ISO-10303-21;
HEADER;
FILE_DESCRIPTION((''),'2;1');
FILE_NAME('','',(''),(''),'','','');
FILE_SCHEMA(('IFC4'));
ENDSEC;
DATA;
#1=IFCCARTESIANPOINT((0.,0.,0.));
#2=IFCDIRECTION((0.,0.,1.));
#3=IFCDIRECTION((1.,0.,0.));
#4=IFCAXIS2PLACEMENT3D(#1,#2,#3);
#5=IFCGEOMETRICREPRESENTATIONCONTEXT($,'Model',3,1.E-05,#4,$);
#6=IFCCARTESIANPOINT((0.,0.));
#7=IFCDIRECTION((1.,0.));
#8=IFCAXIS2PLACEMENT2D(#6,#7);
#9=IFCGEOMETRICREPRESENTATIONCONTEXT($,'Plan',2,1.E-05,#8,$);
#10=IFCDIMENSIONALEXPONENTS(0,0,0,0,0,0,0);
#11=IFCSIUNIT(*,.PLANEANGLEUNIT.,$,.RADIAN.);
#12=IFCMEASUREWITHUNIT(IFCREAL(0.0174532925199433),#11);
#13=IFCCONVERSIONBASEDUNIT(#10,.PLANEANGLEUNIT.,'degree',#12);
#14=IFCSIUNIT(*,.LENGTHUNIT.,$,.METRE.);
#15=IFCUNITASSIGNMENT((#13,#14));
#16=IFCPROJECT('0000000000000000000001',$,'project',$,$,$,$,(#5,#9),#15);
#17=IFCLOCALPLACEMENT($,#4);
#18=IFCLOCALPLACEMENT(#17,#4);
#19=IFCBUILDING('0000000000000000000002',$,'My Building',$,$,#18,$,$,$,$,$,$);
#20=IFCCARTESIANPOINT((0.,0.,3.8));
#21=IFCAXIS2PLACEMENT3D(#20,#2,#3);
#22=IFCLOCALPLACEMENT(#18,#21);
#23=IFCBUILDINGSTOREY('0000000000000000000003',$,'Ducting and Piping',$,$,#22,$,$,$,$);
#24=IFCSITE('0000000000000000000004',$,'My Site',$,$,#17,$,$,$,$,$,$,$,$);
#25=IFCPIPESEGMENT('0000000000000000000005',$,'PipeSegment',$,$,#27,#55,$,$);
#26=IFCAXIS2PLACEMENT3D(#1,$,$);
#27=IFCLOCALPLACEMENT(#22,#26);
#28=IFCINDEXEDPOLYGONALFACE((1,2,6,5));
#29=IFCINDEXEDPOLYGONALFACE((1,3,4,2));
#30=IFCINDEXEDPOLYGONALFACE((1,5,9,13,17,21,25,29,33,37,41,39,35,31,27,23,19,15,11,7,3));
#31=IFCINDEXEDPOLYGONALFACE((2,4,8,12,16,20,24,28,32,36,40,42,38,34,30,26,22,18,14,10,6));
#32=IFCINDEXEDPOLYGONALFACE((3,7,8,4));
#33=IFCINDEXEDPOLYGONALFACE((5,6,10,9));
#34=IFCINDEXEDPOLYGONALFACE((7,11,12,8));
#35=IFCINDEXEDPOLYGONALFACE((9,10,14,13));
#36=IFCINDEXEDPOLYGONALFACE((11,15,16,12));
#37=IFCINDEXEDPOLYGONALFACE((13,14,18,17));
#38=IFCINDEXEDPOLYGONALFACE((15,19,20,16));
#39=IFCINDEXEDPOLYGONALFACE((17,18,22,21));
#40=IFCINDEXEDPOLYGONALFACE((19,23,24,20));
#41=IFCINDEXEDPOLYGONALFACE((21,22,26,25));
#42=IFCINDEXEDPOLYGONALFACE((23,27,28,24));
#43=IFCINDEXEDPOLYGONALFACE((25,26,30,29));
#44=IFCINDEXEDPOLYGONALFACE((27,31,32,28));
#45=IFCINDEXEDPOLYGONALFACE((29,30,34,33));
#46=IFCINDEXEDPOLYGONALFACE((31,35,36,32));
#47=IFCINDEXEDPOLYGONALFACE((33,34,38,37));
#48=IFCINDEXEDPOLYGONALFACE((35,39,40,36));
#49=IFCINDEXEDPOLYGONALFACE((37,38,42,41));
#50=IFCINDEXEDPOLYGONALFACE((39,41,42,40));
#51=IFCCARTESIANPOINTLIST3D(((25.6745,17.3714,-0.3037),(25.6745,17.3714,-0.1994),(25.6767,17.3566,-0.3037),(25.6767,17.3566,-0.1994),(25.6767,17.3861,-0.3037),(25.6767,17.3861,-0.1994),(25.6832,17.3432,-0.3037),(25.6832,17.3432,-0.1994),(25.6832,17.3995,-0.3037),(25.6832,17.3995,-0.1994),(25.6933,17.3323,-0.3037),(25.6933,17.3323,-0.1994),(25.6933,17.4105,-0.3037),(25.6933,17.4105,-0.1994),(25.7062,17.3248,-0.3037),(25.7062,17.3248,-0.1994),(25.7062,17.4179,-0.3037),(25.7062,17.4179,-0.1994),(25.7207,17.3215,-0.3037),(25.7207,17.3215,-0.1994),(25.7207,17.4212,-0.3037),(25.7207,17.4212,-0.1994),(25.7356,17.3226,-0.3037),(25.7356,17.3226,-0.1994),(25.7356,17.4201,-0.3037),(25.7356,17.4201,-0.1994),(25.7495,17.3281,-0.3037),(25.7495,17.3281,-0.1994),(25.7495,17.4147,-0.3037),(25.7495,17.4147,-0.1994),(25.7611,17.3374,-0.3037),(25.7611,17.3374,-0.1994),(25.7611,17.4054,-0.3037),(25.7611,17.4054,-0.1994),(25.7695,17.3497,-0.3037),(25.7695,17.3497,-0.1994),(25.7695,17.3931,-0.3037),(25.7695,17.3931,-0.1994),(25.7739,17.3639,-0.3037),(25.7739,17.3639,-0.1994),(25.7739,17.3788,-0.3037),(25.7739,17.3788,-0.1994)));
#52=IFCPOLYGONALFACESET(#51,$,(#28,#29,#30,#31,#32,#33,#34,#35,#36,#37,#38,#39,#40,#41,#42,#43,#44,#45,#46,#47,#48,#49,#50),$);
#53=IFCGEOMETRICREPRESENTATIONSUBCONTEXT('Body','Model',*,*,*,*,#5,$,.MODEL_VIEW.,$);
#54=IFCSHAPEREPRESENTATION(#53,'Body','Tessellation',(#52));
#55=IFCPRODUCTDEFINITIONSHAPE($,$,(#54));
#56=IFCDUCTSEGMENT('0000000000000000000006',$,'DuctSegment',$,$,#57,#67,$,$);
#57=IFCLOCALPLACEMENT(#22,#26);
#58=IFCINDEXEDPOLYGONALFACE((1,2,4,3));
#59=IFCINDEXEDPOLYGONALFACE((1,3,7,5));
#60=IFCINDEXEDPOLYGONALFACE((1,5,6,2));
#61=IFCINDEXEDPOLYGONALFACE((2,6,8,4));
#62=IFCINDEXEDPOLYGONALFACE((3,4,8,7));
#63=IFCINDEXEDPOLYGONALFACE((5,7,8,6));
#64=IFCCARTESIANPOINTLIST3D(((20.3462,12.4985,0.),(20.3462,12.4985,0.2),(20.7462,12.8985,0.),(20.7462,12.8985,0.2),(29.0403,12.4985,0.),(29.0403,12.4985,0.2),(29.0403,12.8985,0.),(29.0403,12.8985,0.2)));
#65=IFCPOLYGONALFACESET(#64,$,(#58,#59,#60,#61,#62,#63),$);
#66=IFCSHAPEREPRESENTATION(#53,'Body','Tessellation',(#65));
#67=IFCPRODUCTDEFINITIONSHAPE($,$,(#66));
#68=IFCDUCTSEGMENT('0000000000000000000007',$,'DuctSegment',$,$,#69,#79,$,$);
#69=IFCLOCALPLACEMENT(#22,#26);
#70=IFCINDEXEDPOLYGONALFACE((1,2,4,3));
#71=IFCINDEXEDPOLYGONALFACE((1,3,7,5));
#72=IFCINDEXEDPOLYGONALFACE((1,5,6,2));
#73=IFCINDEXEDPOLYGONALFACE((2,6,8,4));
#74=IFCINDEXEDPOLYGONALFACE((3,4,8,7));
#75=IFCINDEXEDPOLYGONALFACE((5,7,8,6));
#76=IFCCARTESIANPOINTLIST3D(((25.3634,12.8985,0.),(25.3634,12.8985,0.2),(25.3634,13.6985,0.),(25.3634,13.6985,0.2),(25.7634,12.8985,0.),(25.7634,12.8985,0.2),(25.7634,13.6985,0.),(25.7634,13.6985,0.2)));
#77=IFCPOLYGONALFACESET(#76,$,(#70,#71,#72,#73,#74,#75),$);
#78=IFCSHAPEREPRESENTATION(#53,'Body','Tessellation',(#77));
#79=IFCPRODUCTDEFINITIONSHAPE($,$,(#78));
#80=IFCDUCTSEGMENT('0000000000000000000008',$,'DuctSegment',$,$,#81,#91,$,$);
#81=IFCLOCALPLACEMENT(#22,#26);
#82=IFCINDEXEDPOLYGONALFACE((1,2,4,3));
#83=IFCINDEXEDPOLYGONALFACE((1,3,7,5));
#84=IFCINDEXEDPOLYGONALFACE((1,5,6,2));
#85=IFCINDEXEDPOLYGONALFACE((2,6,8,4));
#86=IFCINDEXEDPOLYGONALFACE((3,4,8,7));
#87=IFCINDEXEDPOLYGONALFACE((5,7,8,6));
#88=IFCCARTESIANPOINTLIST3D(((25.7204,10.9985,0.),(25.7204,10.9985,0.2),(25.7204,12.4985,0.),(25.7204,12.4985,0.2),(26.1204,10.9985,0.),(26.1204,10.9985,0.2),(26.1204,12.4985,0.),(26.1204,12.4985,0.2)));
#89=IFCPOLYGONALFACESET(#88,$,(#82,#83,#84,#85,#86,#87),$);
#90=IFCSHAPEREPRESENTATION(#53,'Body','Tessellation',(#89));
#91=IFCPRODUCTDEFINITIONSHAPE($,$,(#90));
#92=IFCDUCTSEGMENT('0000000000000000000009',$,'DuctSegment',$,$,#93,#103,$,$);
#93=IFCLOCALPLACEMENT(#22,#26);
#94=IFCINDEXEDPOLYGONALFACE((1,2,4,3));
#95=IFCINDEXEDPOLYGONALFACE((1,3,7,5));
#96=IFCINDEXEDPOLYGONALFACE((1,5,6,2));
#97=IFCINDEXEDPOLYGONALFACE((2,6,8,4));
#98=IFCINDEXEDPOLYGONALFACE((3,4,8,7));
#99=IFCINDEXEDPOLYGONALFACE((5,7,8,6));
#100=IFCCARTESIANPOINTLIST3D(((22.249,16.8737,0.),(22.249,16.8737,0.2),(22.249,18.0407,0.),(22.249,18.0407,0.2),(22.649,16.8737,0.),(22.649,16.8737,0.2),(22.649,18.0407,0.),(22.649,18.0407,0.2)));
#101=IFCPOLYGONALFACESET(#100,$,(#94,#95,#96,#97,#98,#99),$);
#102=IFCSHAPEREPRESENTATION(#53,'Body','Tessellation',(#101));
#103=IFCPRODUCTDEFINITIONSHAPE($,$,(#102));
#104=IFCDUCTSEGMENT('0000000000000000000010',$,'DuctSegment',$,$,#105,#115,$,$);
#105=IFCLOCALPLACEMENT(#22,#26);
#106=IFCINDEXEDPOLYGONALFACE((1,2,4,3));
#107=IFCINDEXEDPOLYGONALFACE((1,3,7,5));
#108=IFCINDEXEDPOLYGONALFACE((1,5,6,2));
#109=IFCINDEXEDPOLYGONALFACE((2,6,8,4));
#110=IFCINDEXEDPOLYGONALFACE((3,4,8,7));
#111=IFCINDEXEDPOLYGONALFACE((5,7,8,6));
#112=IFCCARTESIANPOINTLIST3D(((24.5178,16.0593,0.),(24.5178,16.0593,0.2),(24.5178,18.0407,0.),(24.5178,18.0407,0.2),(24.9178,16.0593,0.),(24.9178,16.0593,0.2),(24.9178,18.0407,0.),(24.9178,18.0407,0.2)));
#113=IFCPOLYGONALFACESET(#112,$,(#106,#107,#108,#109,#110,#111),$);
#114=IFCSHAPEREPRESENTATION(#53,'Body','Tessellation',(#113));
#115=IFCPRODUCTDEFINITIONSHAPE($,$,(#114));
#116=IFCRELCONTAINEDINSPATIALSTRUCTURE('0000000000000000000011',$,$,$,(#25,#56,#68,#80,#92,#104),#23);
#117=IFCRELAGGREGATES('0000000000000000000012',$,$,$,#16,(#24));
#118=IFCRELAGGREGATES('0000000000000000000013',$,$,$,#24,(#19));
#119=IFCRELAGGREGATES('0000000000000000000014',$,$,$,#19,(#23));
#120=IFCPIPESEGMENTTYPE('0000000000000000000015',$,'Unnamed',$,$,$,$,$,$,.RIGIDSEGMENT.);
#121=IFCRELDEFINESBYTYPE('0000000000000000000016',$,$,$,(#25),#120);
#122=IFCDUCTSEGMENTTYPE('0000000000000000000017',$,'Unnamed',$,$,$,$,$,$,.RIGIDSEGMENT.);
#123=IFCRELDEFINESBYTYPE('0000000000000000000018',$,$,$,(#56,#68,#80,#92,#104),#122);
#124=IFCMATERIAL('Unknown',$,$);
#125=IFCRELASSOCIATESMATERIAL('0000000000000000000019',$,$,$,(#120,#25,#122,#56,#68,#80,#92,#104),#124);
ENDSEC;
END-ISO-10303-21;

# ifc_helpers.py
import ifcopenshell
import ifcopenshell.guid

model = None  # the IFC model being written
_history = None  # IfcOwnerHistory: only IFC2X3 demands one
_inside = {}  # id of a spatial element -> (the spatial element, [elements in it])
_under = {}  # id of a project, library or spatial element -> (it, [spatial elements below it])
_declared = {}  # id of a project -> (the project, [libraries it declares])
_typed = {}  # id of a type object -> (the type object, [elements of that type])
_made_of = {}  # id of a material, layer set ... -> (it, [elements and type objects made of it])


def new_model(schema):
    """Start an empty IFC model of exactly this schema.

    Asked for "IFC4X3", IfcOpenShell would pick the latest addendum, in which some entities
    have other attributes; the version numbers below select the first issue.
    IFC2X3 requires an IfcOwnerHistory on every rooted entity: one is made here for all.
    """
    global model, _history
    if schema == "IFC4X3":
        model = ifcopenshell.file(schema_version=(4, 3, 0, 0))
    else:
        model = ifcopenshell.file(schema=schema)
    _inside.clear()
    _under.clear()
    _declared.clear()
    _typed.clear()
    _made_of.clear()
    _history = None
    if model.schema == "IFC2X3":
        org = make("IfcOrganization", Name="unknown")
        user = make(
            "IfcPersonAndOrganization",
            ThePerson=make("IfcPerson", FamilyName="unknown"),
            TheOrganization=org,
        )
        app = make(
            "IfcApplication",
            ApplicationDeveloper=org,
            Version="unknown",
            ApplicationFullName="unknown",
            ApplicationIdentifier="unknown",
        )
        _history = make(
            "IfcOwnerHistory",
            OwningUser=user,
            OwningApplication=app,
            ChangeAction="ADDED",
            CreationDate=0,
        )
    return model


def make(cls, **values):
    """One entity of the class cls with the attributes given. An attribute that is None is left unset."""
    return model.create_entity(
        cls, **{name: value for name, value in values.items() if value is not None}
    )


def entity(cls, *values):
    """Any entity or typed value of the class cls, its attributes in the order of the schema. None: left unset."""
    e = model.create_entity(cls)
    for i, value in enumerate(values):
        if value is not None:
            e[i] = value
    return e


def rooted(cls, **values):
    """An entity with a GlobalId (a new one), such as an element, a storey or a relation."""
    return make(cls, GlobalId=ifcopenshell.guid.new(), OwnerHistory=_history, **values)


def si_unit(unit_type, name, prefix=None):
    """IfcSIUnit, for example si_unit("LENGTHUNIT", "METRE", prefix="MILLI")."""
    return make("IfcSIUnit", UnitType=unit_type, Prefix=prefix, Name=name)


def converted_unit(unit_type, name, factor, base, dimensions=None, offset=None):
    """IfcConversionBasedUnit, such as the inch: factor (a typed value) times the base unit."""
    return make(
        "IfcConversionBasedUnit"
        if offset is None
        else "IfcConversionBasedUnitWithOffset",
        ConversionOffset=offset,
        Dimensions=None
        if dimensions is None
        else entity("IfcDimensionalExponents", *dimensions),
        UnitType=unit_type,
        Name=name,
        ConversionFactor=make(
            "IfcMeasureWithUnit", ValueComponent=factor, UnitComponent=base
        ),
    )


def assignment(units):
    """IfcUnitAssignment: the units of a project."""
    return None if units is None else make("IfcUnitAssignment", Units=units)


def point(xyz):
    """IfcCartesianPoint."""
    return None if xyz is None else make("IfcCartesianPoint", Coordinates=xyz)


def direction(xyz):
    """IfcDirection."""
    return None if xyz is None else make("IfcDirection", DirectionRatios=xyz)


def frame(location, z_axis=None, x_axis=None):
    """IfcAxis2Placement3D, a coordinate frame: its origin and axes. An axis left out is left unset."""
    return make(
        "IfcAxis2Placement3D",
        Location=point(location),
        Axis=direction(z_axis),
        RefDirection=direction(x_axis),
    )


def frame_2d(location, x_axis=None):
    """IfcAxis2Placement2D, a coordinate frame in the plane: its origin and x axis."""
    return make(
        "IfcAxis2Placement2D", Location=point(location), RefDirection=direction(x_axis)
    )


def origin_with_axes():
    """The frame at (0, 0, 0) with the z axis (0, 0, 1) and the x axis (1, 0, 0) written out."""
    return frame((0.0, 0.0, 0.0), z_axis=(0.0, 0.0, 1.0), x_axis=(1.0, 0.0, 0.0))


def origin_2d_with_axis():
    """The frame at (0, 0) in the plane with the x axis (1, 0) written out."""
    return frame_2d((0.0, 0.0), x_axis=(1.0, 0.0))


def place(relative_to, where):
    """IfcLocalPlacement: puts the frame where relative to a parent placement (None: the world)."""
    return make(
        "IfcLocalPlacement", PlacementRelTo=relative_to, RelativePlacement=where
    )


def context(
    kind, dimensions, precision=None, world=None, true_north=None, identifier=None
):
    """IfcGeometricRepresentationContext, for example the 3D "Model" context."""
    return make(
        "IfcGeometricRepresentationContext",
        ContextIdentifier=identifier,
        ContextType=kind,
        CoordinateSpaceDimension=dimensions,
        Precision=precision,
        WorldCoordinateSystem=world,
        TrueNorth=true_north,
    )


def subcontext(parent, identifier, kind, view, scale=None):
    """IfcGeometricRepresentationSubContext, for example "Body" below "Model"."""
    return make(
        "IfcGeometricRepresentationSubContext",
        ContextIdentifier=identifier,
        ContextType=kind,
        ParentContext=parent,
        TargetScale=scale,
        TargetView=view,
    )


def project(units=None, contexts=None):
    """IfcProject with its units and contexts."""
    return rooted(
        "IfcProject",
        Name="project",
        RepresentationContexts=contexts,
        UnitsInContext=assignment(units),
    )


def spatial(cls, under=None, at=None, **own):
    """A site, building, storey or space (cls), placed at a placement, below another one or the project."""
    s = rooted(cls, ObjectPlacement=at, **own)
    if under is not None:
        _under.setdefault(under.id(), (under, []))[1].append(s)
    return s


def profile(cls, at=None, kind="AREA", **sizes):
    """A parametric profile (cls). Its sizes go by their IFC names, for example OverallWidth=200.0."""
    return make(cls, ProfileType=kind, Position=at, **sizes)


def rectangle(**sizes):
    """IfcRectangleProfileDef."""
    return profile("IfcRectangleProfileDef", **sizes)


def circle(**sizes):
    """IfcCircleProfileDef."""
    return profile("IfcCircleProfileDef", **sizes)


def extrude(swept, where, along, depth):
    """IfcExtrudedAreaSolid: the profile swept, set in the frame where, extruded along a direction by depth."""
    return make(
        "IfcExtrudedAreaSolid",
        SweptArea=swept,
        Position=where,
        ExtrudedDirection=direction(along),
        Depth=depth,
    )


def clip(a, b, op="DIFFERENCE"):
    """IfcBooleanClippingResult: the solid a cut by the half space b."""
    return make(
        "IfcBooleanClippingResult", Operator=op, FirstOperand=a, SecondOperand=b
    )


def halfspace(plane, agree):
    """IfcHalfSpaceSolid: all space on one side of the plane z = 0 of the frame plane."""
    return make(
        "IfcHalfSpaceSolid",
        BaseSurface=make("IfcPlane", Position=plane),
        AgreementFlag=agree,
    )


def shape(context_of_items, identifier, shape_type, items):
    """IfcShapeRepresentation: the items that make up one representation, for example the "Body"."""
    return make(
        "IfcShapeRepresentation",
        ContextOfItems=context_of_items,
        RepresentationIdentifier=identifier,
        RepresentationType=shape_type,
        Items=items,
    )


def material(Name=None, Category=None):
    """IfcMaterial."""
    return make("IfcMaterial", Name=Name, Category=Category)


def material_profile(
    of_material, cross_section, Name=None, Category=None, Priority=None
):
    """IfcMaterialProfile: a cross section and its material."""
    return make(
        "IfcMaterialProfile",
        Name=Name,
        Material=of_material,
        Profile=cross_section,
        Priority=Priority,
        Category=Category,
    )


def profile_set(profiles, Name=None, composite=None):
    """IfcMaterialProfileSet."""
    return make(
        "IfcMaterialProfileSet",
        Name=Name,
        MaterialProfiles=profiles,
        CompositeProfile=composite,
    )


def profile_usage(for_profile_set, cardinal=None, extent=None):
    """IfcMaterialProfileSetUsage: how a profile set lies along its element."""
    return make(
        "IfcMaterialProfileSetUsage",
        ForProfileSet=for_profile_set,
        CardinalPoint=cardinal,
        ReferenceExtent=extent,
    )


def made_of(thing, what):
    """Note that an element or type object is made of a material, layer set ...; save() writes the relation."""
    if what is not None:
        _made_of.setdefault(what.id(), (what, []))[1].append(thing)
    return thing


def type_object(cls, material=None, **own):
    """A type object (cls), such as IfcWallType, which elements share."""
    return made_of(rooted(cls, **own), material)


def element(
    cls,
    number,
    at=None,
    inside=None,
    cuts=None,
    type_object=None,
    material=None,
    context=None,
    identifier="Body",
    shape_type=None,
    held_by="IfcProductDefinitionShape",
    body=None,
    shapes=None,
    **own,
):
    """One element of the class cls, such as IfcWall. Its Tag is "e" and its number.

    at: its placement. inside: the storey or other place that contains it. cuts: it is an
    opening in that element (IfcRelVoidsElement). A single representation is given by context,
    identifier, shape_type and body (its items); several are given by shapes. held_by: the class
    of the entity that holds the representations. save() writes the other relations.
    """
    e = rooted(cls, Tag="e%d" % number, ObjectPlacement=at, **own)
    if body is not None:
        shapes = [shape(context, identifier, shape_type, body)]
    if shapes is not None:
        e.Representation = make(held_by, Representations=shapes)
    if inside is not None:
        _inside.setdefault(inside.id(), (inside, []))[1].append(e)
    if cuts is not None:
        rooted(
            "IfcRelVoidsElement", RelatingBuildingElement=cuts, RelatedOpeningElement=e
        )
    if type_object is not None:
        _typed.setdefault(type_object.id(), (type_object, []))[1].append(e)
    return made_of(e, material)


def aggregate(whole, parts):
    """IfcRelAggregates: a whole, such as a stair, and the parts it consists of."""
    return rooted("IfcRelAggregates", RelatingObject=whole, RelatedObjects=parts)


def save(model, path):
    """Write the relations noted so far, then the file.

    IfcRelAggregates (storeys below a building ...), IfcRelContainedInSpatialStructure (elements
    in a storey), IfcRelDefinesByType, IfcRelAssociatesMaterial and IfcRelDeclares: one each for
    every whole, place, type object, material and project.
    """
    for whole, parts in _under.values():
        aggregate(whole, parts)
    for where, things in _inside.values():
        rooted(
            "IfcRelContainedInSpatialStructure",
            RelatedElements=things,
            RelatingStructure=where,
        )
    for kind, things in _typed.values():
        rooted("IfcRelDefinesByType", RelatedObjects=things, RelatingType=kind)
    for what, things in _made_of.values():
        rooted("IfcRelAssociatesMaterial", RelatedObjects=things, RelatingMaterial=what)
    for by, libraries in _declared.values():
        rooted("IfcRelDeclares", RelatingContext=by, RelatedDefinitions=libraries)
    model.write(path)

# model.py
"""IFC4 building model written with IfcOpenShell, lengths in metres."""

from ifc_helpers import new_model, entity, si_unit, converted_unit, frame, origin_with_axes, origin_2d_with_axis, place, context, subcontext, project, spatial, rectangle, circle, extrude, clip, halfspace, material, material_profile, profile_set, profile_usage, type_object, element, save


model = new_model("IFC4")

# Units and contexts
model_context = context("Model", 3, precision=1e-05, world=origin_with_axes())
plan_context = context("Plan", 2, precision=1e-05, world=origin_2d_with_axis())
body_context = subcontext(model_context, "Body", "Model", "MODEL_VIEW")
ifc_project = project(units=[converted_unit("PLANEANGLEUNIT", "degree", entity("IfcReal", 0.0174532925199433), si_unit("PLANEANGLEUNIT", "RADIAN"), dimensions=[0, 0, 0, 0, 0, 0, 0]), si_unit("LENGTHUNIT", "METRE")], contexts=[model_context, plan_context])

# Site, building, storey
site_placement = place(None, origin_with_axes())
site = spatial("IfcSite", under=ifc_project, at=site_placement, Name="My Site")
building_placement = place(site_placement, origin_with_axes())
building = spatial("IfcBuilding", under=site, at=building_placement, Name="My Building")
storey_placement = place(building_placement, frame((0.0, 0.0, 3.8), z_axis=(0.0, 0.0, 1.0), x_axis=(1.0, 0.0, 0.0)))
storey = spatial("IfcBuildingStorey", under=building, at=storey_placement, Name="Ducting and Piping")

# Pipe segment
ifc_material = material(Name="Unknown")
ifc_material_profile_1 = material_profile(ifc_material, circle(Radius=0.05))
ifc_profile_set_1 = profile_set([ifc_material_profile_1])
pipe_segment_type = type_object("IfcPipeSegmentType", Name="Unnamed", PredefinedType="RIGIDSEGMENT", material=ifc_profile_set_1)
ifc_profile_usage_1 = profile_usage(ifc_profile_set_1, cardinal=5)
pipe_segment_1_placement = place(storey_placement, frame((25.7245, 17.3714, -0.3037), z_axis=(0.0, 0.0, 1.0), x_axis=(-1.0, 0.0, 0.0)))
element("IfcPipeSegment", 1, at=pipe_segment_1_placement, inside=storey, type_object=pipe_segment_type, material=ifc_profile_usage_1, Name="PipeSegment", context=body_context, shape_type="SweptSolid", body=[
    extrude(circle(Radius=0.05), origin_with_axes(), (0.0, 0.0, 1.0), 0.1043),
])

# Duct segments
ifc_material_profile_2 = material_profile(ifc_material, rectangle(XDim=0.4, YDim=0.2))
ifc_profile_set_2 = profile_set([ifc_material_profile_2])
ifc_profile_usage_2 = profile_usage(ifc_profile_set_2, cardinal=5)
duct_segment_type = type_object("IfcDuctSegmentType", Name="Unnamed", PredefinedType="RIGIDSEGMENT", material=ifc_profile_set_2)
duct_segment_1_placement = place(storey_placement, frame((29.0403, 12.6985, 0.1), z_axis=(-1.0, 0.0, 0.0), x_axis=(0.0, -1.0, 0.0)))
element("IfcDuctSegment", 2, at=duct_segment_1_placement, inside=storey, type_object=duct_segment_type, material=ifc_profile_usage_2, Name="DuctSegment", context=body_context, shape_type="Clipping", body=[
    clip(extrude(rectangle(XDim=0.4, YDim=0.2), origin_with_axes(), (0.0, 0.0, 1.0), 8.6941), halfspace(frame((0.2, 0.0, 8.6941), z_axis=(-0.707107, 0.0, 0.707107), x_axis=(0.0, 1.0, 0.0)), False)),
])
ifc_profile_usage_3 = profile_usage(ifc_profile_set_2, cardinal=5)
duct_segment_2_placement = place(storey_placement, frame((25.5634, 12.8985, 0.1), z_axis=(0.0, 1.0, 0.0), x_axis=(-1.0, 0.0, 0.0)))
element("IfcDuctSegment", 3, at=duct_segment_2_placement, inside=storey, type_object=duct_segment_type, material=ifc_profile_usage_3, Name="DuctSegment", context=body_context, shape_type="SweptSolid", body=[
    extrude(rectangle(XDim=0.4, YDim=0.2), origin_with_axes(), (0.0, 0.0, 1.0), 0.8),
])
ifc_profile_usage_4 = profile_usage(ifc_profile_set_2, cardinal=5)
duct_segment_3_placement = place(storey_placement, frame((25.9204, 12.4985, 0.1), z_axis=(0.0, -1.0, 0.0), x_axis=(1.0, 0.0, 0.0)))
element("IfcDuctSegment", 4, at=duct_segment_3_placement, inside=storey, type_object=duct_segment_type, material=ifc_profile_usage_4, Name="DuctSegment", context=body_context, shape_type="SweptSolid", body=[
    extrude(rectangle(XDim=0.4, YDim=0.2), origin_with_axes(), (0.0, 0.0, 1.0), 1.5),
])
ifc_profile_usage_5 = profile_usage(ifc_profile_set_2, cardinal=5)
duct_segment_4_placement = place(storey_placement, frame((22.449, 18.0407, 0.1), z_axis=(0.0, -1.0, 0.0), x_axis=(1.0, 0.0, 0.0)))
element("IfcDuctSegment", 5, at=duct_segment_4_placement, inside=storey, type_object=duct_segment_type, material=ifc_profile_usage_5, Name="DuctSegment", context=body_context, shape_type="SweptSolid", body=[
    extrude(rectangle(XDim=0.4, YDim=0.2), origin_with_axes(), (0.0, 0.0, 1.0), 1.1669),
])
ifc_profile_usage_6 = profile_usage(ifc_profile_set_2, cardinal=5)
duct_segment_5_placement = place(storey_placement, frame((24.7178, 18.0407, 0.1), z_axis=(0.0, -1.0, 0.0), x_axis=(1.0, 0.0, 0.0)))
element("IfcDuctSegment", 6, at=duct_segment_5_placement, inside=storey, type_object=duct_segment_type, material=ifc_profile_usage_6, Name="DuctSegment", context=body_context, shape_type="SweptSolid", body=[
    extrude(rectangle(XDim=0.4, YDim=0.2), origin_with_axes(), (0.0, 0.0, 1.0), 1.9814),
])

save(model, "model.ifc")
